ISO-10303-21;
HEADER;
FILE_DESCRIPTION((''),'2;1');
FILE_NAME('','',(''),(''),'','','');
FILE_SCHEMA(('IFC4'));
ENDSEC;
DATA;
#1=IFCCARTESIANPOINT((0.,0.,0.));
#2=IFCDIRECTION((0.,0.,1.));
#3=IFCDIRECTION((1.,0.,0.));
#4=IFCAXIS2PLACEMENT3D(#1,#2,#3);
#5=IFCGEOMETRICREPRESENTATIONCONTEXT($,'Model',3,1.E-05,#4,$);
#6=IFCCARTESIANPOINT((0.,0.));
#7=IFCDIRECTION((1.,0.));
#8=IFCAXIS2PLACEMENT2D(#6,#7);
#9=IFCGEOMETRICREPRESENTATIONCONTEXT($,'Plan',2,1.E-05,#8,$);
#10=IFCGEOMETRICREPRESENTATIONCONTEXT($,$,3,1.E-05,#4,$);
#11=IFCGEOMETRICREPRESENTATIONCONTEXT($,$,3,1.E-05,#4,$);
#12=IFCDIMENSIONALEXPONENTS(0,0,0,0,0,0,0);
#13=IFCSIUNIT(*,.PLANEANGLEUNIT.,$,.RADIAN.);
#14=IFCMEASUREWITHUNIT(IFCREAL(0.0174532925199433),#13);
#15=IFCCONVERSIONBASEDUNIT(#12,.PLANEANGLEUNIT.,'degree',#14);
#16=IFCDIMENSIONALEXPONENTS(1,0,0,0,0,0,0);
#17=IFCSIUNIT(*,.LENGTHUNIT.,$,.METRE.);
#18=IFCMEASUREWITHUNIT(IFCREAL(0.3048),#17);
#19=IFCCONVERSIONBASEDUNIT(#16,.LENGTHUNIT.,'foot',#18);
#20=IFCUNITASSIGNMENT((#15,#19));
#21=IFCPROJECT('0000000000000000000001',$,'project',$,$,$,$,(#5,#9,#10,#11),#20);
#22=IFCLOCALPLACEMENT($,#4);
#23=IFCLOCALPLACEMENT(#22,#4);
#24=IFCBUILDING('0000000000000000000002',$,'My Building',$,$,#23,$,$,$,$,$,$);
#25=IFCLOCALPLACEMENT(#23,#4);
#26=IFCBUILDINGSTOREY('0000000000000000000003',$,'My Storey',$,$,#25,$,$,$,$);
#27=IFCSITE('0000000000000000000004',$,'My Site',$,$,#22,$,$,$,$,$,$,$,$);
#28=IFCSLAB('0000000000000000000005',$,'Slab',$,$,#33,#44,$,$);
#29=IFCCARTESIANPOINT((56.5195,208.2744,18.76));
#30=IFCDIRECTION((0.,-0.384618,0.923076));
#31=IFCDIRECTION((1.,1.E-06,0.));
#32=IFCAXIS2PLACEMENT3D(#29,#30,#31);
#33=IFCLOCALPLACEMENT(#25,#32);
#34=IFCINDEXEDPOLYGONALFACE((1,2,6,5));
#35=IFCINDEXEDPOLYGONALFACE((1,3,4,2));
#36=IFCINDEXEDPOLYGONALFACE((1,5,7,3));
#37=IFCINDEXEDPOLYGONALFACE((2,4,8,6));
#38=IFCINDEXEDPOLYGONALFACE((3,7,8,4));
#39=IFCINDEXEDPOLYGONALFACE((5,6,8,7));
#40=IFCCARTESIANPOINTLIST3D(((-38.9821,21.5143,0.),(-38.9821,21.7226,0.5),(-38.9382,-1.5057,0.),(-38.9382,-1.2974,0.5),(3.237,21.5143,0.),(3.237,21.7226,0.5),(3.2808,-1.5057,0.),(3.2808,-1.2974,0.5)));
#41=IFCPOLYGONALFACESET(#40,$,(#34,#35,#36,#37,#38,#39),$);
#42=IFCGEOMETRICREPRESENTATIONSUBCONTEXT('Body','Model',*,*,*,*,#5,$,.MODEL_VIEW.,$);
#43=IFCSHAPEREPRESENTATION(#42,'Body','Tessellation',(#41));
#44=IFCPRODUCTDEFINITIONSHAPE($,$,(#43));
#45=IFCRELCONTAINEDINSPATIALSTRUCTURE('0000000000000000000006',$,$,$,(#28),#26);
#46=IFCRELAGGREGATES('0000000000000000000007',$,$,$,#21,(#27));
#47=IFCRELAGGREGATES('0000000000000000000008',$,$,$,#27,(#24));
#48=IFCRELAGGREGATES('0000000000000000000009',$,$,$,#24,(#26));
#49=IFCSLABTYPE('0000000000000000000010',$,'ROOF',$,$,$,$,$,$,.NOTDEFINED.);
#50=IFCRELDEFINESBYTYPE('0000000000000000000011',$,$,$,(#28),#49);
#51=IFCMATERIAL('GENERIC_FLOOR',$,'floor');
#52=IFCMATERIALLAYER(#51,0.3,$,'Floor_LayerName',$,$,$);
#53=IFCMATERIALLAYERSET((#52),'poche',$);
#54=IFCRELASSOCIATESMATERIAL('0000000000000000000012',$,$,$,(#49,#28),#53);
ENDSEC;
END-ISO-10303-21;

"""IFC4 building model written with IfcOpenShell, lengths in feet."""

from ifc_helpers import new_model, entity, si_unit, converted_unit, frame, origin_with_axes, origin_2d_with_axis, place, context, subcontext, project, spatial, line, indexed_curve, outline, extrude, material, layer, layer_set, layer_usage, type_object, element, save


model = new_model("IFC4")

# Units and contexts
model_context = context("Model", 3, precision=1e-05, world=origin_with_axes())
plan_context = context("Plan", 2, precision=1e-05, world=origin_2d_with_axis())
context_of_model_1 = context(None, 3, precision=1e-05, world=origin_with_axes())
context_of_model_2 = context(None, 3, precision=1e-05, world=origin_with_axes())
body_context = subcontext(model_context, "Body", "Model", "MODEL_VIEW")
ifc_project = project(units=[converted_unit("PLANEANGLEUNIT", "degree", entity("IfcReal", 0.0174532925199433), si_unit("PLANEANGLEUNIT", "RADIAN"), dimensions=[0, 0, 0, 0, 0, 0, 0]), converted_unit("LENGTHUNIT", "foot", entity("IfcReal", 0.3048), si_unit("LENGTHUNIT", "METRE"), dimensions=[1, 0, 0, 0, 0, 0, 0])], contexts=[model_context, plan_context, context_of_model_1, context_of_model_2])

# Site, building, storey
site_placement = place(None, origin_with_axes())
site = spatial("IfcSite", under=ifc_project, at=site_placement, Name="My Site")
building_placement = place(site_placement, origin_with_axes())
building = spatial("IfcBuilding", under=site, at=building_placement, Name="My Building")
storey_placement = place(building_placement, origin_with_axes())
storey = spatial("IfcBuildingStorey", under=building, at=storey_placement, Name="My Storey")

# Shared definitions
ifc_material_1 = material(Name="GENERIC_FLOOR", Category="floor")
ifc_layer_1 = layer(ifc_material_1, 0.3, Name="Floor_LayerName")
ifc_layer_set_1 = layer_set([ifc_layer_1], Name="poche")
slab_type = type_object("IfcSlabType", Name="ROOF", PredefinedType="NOTDEFINED", material=ifc_layer_set_1)

# Slab
ifc_layer_usage_1 = layer_usage(ifc_layer_set_1, "AXIS3", "POSITIVE", 0.0)
slab_1_placement = place(storey_placement, frame((56.5195, 208.2744, 18.76), z_axis=(0.0, -0.384618, 0.923076), x_axis=(1.0, 0.000001, 0.0)))
element("IfcSlab", 1, at=slab_1_placement, inside=storey, type_object=slab_type, material=ifc_layer_usage_1, Name="Slab", context=body_context, shape_type="SweptSolid", body=[
    extrude(outline(indexed_curve([(-38.9821, 21.5143), (3.237, 21.5143), (3.2808, -1.5057), (-38.9382, -1.5057)], segments=[line(3, 2), line(2, 1), line(1, 4), line(4, 3)], self_intersect=False)), None, (0.0, 0.384618, 0.923076), 0.5417),
])

save(model, "model.ifc")
